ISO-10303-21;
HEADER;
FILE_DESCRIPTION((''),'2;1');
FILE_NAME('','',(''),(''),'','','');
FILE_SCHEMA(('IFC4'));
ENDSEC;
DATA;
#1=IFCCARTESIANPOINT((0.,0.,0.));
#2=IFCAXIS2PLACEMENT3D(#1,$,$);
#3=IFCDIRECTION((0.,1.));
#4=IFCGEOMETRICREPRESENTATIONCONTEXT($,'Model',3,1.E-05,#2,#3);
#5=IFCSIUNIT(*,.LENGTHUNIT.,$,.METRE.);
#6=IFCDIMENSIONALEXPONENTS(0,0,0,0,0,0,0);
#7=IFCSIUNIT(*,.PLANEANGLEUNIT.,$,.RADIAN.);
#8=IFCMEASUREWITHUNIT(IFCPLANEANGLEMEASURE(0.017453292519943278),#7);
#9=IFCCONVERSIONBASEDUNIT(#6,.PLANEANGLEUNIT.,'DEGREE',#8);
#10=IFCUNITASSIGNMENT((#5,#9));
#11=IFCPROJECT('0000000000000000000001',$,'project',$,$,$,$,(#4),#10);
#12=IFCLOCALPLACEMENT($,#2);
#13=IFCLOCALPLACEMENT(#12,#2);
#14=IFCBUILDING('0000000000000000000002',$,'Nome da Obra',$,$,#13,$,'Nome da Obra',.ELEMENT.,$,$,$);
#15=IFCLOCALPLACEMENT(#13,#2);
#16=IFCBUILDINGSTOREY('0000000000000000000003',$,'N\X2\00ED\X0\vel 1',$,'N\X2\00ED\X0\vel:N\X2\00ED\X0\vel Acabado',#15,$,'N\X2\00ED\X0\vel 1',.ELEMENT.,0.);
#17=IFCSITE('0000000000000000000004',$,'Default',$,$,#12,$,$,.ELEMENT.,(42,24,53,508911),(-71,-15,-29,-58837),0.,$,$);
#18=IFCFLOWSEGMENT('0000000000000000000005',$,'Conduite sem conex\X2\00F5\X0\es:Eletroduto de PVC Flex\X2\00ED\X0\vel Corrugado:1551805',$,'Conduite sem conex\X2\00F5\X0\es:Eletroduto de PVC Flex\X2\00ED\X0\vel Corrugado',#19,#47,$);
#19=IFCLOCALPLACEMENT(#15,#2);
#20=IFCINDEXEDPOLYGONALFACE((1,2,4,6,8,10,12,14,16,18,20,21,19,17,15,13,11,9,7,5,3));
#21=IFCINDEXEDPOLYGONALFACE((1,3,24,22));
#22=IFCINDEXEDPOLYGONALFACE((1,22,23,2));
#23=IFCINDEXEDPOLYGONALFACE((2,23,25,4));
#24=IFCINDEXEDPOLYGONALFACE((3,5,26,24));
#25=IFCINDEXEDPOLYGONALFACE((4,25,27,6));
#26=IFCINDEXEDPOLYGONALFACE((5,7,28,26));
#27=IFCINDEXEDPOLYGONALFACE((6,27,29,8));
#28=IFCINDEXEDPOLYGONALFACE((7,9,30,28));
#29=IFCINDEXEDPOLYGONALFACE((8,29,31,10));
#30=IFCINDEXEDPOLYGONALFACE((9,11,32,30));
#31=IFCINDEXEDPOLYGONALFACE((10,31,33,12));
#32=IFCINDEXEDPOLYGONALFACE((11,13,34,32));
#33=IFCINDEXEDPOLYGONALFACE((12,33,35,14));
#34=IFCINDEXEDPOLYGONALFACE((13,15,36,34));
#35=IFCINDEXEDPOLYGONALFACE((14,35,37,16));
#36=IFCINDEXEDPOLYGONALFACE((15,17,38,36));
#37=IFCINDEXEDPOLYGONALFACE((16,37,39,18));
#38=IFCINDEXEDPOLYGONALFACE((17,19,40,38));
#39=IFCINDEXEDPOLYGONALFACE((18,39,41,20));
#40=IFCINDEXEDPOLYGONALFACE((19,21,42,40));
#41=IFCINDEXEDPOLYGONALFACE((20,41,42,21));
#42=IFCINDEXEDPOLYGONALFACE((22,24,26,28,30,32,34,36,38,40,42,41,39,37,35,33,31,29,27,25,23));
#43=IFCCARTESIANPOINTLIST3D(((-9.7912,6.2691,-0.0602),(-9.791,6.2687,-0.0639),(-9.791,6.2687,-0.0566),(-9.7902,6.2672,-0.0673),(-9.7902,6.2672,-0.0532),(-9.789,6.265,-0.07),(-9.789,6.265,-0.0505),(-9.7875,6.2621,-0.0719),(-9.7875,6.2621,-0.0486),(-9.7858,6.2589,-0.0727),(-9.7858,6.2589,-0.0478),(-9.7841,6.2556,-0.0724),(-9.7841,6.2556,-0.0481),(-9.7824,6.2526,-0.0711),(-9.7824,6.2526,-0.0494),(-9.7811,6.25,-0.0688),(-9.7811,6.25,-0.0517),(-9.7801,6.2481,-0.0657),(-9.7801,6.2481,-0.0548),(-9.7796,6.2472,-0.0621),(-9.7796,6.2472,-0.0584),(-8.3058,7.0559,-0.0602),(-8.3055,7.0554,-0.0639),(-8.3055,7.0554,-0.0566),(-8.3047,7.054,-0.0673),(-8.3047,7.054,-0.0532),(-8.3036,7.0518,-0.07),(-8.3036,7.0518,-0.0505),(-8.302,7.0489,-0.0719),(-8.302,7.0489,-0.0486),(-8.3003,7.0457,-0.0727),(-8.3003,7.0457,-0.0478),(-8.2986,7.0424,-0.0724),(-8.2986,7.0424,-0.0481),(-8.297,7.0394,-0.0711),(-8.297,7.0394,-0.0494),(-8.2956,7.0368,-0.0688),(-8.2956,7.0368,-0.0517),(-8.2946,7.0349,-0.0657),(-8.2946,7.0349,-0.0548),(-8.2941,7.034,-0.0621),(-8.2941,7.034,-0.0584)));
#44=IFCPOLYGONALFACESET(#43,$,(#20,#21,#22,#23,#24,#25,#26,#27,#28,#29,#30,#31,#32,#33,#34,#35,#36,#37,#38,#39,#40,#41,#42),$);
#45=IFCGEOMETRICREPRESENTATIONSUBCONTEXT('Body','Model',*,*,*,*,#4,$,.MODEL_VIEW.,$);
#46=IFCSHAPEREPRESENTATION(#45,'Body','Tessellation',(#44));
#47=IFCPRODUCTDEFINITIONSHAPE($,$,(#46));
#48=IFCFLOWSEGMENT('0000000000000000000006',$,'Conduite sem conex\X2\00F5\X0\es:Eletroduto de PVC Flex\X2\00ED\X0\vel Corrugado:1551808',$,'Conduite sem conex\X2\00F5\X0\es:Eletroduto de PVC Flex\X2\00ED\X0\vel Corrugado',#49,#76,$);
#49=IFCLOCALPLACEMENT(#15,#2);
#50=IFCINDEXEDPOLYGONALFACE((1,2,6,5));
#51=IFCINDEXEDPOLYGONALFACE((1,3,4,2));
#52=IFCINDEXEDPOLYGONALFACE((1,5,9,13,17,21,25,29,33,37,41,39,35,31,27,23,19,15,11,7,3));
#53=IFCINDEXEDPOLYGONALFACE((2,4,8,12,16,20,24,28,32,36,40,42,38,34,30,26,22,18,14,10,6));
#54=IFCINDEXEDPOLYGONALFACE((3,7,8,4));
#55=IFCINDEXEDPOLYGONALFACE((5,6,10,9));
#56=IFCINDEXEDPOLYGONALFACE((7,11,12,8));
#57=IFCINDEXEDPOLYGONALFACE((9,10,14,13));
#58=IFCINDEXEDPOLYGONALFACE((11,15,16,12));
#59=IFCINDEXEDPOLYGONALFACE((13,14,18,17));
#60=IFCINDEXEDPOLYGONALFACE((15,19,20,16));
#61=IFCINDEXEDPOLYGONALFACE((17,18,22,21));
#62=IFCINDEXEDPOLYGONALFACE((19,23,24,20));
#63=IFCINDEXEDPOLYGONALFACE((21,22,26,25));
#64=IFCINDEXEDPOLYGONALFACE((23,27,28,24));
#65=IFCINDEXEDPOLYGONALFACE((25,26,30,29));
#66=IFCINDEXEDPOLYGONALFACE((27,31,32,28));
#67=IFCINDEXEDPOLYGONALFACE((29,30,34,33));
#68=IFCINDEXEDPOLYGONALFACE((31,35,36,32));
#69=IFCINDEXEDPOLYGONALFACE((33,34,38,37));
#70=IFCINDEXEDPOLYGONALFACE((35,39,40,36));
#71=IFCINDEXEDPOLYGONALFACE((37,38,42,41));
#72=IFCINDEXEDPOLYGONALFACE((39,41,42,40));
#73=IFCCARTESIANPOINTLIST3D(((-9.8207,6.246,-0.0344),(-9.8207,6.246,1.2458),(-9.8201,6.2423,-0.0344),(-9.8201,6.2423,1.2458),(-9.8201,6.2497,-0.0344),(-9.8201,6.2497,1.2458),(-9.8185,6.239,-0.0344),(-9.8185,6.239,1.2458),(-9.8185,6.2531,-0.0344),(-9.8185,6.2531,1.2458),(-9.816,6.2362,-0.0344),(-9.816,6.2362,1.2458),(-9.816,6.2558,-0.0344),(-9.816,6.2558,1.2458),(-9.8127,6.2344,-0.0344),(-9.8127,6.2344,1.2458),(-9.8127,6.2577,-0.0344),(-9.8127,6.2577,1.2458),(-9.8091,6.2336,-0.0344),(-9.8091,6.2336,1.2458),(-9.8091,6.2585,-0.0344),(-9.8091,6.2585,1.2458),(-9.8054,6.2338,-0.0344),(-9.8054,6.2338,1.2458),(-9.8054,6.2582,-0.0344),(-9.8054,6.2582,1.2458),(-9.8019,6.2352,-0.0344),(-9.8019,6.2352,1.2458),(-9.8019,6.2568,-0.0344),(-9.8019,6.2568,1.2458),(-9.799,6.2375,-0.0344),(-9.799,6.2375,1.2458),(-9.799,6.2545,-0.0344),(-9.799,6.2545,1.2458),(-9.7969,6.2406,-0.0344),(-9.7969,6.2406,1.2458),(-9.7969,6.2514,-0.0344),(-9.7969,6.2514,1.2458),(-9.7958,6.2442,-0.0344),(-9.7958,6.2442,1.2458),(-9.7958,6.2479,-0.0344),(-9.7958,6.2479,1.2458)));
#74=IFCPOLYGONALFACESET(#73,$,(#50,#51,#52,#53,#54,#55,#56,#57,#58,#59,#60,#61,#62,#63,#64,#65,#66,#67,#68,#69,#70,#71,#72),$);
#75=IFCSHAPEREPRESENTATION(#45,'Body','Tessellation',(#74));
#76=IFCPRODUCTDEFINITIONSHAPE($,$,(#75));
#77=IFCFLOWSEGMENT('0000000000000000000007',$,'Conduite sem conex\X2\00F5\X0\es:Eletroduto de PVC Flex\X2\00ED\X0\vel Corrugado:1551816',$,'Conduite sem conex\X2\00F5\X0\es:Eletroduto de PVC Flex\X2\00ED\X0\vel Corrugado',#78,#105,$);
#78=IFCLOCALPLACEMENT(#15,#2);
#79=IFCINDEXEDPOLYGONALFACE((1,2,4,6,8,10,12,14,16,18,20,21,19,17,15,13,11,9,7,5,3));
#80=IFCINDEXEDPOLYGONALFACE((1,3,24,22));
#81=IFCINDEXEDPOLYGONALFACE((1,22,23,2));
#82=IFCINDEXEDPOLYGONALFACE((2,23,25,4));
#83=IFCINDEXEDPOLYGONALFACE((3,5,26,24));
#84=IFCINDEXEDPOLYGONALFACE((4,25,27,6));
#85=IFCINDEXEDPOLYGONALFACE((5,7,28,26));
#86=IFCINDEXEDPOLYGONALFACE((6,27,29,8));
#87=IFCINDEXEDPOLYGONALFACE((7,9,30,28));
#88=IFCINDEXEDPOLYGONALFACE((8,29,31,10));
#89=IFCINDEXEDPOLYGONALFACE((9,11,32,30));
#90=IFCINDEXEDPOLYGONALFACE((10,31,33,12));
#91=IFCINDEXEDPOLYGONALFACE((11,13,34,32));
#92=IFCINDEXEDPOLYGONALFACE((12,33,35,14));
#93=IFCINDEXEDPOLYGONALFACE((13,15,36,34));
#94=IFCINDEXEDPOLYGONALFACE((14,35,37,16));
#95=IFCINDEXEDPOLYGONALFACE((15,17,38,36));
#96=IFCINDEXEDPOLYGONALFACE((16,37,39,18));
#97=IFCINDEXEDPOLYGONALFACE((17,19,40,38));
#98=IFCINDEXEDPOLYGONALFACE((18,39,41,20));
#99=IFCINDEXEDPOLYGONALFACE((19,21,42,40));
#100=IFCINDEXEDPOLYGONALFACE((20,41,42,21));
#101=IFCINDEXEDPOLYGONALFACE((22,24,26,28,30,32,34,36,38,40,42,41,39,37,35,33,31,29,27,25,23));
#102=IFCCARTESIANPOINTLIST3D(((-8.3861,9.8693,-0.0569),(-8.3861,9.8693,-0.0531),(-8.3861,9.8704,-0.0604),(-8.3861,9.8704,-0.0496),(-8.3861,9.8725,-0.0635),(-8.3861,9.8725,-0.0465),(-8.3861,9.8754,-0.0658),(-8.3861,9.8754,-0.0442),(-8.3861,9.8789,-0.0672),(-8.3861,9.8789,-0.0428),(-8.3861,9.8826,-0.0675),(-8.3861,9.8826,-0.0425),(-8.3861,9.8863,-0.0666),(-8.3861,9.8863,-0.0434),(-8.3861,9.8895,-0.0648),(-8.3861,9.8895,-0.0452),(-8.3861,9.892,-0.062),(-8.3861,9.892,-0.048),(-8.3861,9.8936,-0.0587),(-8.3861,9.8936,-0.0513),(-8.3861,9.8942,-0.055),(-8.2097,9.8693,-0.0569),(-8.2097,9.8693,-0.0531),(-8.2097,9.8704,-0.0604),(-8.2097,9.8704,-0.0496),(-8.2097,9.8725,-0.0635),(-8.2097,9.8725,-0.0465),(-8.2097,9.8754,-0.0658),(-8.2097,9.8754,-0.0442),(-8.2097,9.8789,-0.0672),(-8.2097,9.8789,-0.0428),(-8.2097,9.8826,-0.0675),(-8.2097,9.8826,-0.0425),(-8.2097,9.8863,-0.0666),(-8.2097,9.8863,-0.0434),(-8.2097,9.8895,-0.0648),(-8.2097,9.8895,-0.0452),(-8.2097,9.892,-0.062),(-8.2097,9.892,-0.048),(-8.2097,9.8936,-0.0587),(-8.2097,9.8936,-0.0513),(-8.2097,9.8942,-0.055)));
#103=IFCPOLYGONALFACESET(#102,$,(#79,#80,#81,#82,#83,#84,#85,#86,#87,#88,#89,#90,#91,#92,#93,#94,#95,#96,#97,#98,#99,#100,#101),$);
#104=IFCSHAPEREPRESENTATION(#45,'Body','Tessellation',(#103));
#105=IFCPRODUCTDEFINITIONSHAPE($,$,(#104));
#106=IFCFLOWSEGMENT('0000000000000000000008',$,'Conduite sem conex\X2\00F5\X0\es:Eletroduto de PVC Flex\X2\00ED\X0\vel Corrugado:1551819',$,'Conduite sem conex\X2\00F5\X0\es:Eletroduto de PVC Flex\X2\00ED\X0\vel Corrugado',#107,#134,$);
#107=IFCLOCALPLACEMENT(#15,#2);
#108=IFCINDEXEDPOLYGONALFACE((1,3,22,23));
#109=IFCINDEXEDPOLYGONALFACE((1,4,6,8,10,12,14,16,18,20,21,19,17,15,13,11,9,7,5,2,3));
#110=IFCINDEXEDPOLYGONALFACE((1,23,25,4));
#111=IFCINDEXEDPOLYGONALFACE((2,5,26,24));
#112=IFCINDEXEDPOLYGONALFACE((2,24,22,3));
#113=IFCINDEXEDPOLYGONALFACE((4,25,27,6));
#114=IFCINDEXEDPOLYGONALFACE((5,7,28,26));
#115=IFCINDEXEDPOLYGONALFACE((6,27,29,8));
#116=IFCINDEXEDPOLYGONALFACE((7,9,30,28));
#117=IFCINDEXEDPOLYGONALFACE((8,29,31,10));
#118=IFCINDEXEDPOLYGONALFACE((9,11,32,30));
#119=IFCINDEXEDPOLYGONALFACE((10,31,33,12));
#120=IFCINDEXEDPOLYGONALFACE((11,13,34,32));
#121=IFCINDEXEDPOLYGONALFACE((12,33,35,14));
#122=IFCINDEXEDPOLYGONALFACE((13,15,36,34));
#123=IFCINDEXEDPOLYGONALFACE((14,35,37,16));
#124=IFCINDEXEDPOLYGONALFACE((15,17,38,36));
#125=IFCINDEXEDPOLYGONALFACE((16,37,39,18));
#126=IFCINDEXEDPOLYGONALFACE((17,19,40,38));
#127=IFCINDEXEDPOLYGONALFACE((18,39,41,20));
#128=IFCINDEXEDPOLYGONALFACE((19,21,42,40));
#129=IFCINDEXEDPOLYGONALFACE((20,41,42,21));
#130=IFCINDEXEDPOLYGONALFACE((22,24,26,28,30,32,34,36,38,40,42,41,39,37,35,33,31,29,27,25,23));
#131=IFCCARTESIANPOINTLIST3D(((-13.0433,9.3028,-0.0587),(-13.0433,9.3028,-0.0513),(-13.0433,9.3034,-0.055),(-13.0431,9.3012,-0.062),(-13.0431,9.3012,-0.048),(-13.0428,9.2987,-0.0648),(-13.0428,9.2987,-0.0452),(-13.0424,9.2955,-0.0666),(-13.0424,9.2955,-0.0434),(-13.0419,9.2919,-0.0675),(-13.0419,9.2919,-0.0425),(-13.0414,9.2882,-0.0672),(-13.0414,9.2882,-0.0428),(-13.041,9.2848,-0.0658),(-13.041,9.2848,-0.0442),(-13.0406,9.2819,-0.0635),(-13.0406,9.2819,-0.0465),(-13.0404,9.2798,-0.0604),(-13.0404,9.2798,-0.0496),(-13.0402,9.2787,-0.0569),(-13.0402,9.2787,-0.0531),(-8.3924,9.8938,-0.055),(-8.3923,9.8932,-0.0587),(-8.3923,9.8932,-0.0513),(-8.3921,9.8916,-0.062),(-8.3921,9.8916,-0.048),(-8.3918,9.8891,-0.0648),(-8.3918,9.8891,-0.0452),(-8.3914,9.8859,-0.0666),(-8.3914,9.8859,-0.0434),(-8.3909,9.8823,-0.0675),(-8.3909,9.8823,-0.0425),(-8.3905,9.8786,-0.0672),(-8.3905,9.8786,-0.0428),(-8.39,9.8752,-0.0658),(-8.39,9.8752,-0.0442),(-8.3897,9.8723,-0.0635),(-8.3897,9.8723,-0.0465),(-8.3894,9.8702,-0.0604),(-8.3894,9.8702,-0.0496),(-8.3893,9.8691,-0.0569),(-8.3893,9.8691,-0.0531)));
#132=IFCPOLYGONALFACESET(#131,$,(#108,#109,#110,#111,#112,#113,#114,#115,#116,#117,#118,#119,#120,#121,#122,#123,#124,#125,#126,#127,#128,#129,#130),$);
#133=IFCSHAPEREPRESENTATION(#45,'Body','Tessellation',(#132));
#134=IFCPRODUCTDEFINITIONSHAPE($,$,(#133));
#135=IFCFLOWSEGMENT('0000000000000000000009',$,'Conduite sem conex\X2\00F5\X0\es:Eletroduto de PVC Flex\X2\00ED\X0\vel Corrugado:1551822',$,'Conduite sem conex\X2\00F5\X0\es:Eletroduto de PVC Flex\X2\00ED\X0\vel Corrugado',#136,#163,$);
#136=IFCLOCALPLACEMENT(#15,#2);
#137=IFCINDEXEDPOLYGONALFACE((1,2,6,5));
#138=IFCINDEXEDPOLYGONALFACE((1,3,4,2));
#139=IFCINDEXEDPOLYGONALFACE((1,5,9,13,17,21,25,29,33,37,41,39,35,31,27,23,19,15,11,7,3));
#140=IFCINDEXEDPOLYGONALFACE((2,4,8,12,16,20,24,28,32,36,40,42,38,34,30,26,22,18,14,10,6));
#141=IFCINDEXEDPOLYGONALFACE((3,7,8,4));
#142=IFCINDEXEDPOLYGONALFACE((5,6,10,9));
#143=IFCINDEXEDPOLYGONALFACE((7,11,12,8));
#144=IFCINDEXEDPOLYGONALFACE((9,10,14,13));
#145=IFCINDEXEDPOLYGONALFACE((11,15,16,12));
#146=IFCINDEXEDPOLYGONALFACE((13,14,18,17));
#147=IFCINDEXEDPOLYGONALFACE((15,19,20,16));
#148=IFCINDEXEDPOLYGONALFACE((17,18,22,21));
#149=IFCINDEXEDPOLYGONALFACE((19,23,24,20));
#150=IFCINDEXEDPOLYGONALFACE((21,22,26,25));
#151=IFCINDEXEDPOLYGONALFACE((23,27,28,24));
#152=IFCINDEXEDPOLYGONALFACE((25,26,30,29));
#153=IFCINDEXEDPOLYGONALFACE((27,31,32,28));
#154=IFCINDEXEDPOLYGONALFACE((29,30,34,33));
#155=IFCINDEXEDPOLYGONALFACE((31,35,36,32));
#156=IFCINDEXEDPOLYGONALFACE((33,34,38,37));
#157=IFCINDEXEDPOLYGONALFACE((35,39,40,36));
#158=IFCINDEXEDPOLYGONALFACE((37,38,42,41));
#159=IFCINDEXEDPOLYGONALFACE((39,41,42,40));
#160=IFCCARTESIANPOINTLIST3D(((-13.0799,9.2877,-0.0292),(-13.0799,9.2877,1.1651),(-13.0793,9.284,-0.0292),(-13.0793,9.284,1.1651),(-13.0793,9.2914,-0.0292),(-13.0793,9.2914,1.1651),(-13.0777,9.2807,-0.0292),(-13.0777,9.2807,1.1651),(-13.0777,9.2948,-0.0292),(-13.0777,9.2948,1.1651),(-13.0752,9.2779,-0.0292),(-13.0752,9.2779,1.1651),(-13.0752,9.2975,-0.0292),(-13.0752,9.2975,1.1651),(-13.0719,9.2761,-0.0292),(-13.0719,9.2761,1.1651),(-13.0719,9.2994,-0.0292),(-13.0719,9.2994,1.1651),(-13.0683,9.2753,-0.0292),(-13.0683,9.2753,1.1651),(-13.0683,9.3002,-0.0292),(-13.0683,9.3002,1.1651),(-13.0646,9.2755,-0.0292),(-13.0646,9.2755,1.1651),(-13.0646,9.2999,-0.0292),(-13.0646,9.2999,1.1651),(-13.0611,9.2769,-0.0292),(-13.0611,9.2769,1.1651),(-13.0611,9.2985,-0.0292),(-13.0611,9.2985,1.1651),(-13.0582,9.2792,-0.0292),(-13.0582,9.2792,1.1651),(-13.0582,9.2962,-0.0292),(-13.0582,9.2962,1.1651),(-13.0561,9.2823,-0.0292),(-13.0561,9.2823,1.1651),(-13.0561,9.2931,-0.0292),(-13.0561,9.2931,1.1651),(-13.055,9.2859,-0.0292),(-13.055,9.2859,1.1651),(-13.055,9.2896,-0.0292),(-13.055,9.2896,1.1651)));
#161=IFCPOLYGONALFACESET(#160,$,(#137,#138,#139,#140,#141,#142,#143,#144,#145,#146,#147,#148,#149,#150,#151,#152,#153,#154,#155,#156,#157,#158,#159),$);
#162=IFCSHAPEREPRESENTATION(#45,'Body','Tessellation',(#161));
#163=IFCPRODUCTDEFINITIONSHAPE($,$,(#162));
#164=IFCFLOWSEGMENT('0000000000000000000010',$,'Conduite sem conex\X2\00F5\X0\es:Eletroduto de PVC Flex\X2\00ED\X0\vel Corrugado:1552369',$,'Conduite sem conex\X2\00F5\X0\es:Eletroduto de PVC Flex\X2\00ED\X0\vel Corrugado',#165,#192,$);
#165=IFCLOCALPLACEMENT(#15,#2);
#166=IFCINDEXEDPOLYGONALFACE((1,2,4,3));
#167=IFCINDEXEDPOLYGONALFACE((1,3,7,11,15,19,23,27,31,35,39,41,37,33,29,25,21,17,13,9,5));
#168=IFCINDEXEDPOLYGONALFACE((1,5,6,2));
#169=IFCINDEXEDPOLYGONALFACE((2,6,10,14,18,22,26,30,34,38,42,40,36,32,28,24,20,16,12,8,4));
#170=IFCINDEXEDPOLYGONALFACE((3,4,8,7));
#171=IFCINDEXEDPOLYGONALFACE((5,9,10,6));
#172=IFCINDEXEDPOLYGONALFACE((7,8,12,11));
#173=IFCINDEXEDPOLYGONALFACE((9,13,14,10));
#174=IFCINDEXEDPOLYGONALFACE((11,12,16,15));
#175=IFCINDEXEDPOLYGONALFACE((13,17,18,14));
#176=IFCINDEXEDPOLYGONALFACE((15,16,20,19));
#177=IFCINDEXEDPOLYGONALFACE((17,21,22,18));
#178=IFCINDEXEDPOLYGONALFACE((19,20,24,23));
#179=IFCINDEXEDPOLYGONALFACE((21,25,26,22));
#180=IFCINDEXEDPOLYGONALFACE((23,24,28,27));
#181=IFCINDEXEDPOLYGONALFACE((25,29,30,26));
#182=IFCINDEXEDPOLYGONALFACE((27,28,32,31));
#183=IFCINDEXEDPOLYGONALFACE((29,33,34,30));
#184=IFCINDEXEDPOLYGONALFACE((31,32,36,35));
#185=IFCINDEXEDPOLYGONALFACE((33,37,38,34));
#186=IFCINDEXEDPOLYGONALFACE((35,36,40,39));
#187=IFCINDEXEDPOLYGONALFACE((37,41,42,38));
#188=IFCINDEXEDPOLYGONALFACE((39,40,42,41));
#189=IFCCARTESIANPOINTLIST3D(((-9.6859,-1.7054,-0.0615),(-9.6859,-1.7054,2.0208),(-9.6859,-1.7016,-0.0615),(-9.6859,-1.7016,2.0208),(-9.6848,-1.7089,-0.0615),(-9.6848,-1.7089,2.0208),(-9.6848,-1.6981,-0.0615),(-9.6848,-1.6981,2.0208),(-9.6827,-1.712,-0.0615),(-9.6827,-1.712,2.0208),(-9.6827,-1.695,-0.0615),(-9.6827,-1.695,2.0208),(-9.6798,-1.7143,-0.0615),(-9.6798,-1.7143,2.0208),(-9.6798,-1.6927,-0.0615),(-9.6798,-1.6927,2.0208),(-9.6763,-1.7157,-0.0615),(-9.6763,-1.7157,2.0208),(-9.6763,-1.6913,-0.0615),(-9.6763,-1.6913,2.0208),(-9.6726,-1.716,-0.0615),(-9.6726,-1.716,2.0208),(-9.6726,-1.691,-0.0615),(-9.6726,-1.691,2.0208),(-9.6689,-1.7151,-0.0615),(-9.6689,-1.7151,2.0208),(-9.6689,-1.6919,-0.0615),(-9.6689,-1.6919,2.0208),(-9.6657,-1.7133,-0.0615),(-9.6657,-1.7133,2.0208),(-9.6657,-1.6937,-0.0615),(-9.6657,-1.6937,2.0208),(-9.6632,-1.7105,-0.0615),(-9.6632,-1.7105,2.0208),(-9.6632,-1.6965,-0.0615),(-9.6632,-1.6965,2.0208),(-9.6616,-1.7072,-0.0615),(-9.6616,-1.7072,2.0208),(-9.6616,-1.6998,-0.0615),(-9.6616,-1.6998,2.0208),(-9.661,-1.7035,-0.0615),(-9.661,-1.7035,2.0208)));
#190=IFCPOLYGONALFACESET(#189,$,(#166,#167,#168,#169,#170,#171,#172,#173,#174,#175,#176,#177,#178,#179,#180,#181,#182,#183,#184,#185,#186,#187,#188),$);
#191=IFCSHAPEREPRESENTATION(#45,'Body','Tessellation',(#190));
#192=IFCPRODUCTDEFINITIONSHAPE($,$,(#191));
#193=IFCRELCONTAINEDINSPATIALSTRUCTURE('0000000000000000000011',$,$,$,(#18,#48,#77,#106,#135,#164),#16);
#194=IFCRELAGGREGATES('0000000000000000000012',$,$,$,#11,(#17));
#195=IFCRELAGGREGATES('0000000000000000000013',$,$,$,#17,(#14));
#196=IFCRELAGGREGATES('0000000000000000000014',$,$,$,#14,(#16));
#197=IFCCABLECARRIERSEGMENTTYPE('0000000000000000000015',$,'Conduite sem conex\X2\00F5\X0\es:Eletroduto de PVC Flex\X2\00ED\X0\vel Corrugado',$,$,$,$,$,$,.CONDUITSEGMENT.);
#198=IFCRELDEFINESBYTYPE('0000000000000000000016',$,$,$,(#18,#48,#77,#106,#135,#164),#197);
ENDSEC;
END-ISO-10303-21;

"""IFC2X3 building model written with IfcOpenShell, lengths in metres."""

from ifc_helpers import new_model, entity, si_unit, converted_unit, direction, frame, frame_2d, origin, place, context, subcontext, project, spatial, circle, extrude, type_object, element, save


model = new_model("IFC2X3")

# Units and contexts
model_context = context("Model", 3, precision=1e-05, world=origin(), true_north=direction((0.0, 1.0)))
body_context = subcontext(model_context, "Body", "Model", "MODEL_VIEW")
ifc_project = project(units=[si_unit("LENGTHUNIT", "METRE"), converted_unit("PLANEANGLEUNIT", "DEGREE", entity("IfcPlaneAngleMeasure", 0.017453292519943278), si_unit("PLANEANGLEUNIT", "RADIAN"), dimensions=[0, 0, 0, 0, 0, 0, 0])], contexts=[model_context])

# Site, building, storey
site_placement = place(None, origin())
site = spatial("IfcSite", under=ifc_project, at=site_placement, Name="Default", CompositionType="ELEMENT", RefLatitude=(42, 24, 53, 508911), RefLongitude=(-71, -15, -29, -58837), RefElevation=0.0)
building_placement = place(site_placement, origin())
building = spatial("IfcBuilding", under=site, at=building_placement, Name="Nome da Obra", LongName="Nome da Obra", CompositionType="ELEMENT")
storey_placement = place(building_placement, origin())
storey = spatial("IfcBuildingStorey", under=building, at=storey_placement, Name="Nível 1", ObjectType="Nível:Nível Acabado", LongName="Nível 1", CompositionType="ELEMENT", Elevation=0.0)

# Flow segments
cable_carrier_segment_type = type_object("IfcCableCarrierSegmentType", Name="Conduite sem conexões:Eletroduto de PVC Flexível Corrugado", PredefinedType="CONDUITSEGMENT")
flow_segment_1_placement = place(storey_placement, origin())
element("IfcFlowSegment", 1, at=flow_segment_1_placement, inside=storey, type_object=cable_carrier_segment_type, Name="Conduite sem conexões:Eletroduto de PVC Flexível Corrugado:1551805", ObjectType="Conduite sem conexões:Eletroduto de PVC Flexível Corrugado", context=body_context, shape_type="SweptSolid", body=[
    extrude(circle(Radius=0.0125, at=frame_2d((0.0, 0.0), x_axis=(1.0, 0.0))), frame((-9.7854, 6.2581, -0.0602), z_axis=(0.883696, 0.468061, 0.0), x_axis=(-0.468061, 0.883696, 0.0)), (0.0, 0.0, 1.0), 1.681),
])
flow_segment_2_placement = place(storey_placement, origin())
element("IfcFlowSegment", 2, at=flow_segment_2_placement, inside=storey, type_object=cable_carrier_segment_type, Name="Conduite sem conexões:Eletroduto de PVC Flexível Corrugado:1551808", ObjectType="Conduite sem conexões:Eletroduto de PVC Flexível Corrugado", context=body_context, shape_type="SweptSolid", body=[
    extrude(circle(Radius=0.0125, at=frame_2d((0.0, 0.0), x_axis=(1.0, 0.0))), frame((-9.8082, 6.246, -0.0344), z_axis=(0.0, 0.0, 1.0), x_axis=(-1.0, 0.0, 0.0)), (0.0, 0.0, 1.0), 1.2802),
])
flow_segment_3_placement = place(storey_placement, origin())
element("IfcFlowSegment", 3, at=flow_segment_3_placement, inside=storey, type_object=cable_carrier_segment_type, Name="Conduite sem conexões:Eletroduto de PVC Flexível Corrugado:1551816", ObjectType="Conduite sem conexões:Eletroduto de PVC Flexível Corrugado", context=body_context, shape_type="SweptSolid", body=[
    extrude(circle(Radius=0.0125, at=frame_2d((0.0, 0.0), x_axis=(1.0, 0.0))), frame((-8.3861, 9.8817, -0.055), z_axis=(1.0, 0.0, 0.0), x_axis=(0.0, 1.0, 0.0)), (0.0, 0.0, 1.0), 0.1764),
])
flow_segment_4_placement = place(storey_placement, origin())
element("IfcFlowSegment", 4, at=flow_segment_4_placement, inside=storey, type_object=cable_carrier_segment_type, Name="Conduite sem conexões:Eletroduto de PVC Flexível Corrugado:1551819", ObjectType="Conduite sem conexões:Eletroduto de PVC Flexível Corrugado", context=body_context, shape_type="SweptSolid", body=[
    extrude(circle(Radius=0.0125, at=frame_2d((0.0, 0.0), x_axis=(1.0, 0.0))), frame((-13.0418, 9.291, -0.055), z_axis=(0.992038, 0.125938, 0.0), x_axis=(-0.125938, 0.992038, 0.0)), (0.0, 0.0, 1.0), 4.6883),
])
flow_segment_5_placement = place(storey_placement, origin())
element("IfcFlowSegment", 5, at=flow_segment_5_placement, inside=storey, type_object=cable_carrier_segment_type, Name="Conduite sem conexões:Eletroduto de PVC Flexível Corrugado:1551822", ObjectType="Conduite sem conexões:Eletroduto de PVC Flexível Corrugado", context=body_context, shape_type="SweptSolid", body=[
    extrude(circle(Radius=0.0125, at=frame_2d((0.0, 0.0), x_axis=(1.0, 0.0))), frame((-13.0674, 9.2877, -0.0292), z_axis=(0.0, 0.0, 1.0), x_axis=(-1.0, 0.0, 0.0)), (0.0, 0.0, 1.0), 1.1943),
])
flow_segment_6_placement = place(storey_placement, origin())
element("IfcFlowSegment", 6, at=flow_segment_6_placement, inside=storey, type_object=cable_carrier_segment_type, Name="Conduite sem conexões:Eletroduto de PVC Flexível Corrugado:1552369", ObjectType="Conduite sem conexões:Eletroduto de PVC Flexível Corrugado", context=body_context, shape_type="SweptSolid", body=[
    extrude(circle(Radius=0.0125, at=frame_2d((0.0, 0.0), x_axis=(1.0, 0.0))), frame((-9.6735, -1.7035, -0.0615)), (0.0, 0.0, 1.0), 2.0822),
])

save(model, "model.ifc")
